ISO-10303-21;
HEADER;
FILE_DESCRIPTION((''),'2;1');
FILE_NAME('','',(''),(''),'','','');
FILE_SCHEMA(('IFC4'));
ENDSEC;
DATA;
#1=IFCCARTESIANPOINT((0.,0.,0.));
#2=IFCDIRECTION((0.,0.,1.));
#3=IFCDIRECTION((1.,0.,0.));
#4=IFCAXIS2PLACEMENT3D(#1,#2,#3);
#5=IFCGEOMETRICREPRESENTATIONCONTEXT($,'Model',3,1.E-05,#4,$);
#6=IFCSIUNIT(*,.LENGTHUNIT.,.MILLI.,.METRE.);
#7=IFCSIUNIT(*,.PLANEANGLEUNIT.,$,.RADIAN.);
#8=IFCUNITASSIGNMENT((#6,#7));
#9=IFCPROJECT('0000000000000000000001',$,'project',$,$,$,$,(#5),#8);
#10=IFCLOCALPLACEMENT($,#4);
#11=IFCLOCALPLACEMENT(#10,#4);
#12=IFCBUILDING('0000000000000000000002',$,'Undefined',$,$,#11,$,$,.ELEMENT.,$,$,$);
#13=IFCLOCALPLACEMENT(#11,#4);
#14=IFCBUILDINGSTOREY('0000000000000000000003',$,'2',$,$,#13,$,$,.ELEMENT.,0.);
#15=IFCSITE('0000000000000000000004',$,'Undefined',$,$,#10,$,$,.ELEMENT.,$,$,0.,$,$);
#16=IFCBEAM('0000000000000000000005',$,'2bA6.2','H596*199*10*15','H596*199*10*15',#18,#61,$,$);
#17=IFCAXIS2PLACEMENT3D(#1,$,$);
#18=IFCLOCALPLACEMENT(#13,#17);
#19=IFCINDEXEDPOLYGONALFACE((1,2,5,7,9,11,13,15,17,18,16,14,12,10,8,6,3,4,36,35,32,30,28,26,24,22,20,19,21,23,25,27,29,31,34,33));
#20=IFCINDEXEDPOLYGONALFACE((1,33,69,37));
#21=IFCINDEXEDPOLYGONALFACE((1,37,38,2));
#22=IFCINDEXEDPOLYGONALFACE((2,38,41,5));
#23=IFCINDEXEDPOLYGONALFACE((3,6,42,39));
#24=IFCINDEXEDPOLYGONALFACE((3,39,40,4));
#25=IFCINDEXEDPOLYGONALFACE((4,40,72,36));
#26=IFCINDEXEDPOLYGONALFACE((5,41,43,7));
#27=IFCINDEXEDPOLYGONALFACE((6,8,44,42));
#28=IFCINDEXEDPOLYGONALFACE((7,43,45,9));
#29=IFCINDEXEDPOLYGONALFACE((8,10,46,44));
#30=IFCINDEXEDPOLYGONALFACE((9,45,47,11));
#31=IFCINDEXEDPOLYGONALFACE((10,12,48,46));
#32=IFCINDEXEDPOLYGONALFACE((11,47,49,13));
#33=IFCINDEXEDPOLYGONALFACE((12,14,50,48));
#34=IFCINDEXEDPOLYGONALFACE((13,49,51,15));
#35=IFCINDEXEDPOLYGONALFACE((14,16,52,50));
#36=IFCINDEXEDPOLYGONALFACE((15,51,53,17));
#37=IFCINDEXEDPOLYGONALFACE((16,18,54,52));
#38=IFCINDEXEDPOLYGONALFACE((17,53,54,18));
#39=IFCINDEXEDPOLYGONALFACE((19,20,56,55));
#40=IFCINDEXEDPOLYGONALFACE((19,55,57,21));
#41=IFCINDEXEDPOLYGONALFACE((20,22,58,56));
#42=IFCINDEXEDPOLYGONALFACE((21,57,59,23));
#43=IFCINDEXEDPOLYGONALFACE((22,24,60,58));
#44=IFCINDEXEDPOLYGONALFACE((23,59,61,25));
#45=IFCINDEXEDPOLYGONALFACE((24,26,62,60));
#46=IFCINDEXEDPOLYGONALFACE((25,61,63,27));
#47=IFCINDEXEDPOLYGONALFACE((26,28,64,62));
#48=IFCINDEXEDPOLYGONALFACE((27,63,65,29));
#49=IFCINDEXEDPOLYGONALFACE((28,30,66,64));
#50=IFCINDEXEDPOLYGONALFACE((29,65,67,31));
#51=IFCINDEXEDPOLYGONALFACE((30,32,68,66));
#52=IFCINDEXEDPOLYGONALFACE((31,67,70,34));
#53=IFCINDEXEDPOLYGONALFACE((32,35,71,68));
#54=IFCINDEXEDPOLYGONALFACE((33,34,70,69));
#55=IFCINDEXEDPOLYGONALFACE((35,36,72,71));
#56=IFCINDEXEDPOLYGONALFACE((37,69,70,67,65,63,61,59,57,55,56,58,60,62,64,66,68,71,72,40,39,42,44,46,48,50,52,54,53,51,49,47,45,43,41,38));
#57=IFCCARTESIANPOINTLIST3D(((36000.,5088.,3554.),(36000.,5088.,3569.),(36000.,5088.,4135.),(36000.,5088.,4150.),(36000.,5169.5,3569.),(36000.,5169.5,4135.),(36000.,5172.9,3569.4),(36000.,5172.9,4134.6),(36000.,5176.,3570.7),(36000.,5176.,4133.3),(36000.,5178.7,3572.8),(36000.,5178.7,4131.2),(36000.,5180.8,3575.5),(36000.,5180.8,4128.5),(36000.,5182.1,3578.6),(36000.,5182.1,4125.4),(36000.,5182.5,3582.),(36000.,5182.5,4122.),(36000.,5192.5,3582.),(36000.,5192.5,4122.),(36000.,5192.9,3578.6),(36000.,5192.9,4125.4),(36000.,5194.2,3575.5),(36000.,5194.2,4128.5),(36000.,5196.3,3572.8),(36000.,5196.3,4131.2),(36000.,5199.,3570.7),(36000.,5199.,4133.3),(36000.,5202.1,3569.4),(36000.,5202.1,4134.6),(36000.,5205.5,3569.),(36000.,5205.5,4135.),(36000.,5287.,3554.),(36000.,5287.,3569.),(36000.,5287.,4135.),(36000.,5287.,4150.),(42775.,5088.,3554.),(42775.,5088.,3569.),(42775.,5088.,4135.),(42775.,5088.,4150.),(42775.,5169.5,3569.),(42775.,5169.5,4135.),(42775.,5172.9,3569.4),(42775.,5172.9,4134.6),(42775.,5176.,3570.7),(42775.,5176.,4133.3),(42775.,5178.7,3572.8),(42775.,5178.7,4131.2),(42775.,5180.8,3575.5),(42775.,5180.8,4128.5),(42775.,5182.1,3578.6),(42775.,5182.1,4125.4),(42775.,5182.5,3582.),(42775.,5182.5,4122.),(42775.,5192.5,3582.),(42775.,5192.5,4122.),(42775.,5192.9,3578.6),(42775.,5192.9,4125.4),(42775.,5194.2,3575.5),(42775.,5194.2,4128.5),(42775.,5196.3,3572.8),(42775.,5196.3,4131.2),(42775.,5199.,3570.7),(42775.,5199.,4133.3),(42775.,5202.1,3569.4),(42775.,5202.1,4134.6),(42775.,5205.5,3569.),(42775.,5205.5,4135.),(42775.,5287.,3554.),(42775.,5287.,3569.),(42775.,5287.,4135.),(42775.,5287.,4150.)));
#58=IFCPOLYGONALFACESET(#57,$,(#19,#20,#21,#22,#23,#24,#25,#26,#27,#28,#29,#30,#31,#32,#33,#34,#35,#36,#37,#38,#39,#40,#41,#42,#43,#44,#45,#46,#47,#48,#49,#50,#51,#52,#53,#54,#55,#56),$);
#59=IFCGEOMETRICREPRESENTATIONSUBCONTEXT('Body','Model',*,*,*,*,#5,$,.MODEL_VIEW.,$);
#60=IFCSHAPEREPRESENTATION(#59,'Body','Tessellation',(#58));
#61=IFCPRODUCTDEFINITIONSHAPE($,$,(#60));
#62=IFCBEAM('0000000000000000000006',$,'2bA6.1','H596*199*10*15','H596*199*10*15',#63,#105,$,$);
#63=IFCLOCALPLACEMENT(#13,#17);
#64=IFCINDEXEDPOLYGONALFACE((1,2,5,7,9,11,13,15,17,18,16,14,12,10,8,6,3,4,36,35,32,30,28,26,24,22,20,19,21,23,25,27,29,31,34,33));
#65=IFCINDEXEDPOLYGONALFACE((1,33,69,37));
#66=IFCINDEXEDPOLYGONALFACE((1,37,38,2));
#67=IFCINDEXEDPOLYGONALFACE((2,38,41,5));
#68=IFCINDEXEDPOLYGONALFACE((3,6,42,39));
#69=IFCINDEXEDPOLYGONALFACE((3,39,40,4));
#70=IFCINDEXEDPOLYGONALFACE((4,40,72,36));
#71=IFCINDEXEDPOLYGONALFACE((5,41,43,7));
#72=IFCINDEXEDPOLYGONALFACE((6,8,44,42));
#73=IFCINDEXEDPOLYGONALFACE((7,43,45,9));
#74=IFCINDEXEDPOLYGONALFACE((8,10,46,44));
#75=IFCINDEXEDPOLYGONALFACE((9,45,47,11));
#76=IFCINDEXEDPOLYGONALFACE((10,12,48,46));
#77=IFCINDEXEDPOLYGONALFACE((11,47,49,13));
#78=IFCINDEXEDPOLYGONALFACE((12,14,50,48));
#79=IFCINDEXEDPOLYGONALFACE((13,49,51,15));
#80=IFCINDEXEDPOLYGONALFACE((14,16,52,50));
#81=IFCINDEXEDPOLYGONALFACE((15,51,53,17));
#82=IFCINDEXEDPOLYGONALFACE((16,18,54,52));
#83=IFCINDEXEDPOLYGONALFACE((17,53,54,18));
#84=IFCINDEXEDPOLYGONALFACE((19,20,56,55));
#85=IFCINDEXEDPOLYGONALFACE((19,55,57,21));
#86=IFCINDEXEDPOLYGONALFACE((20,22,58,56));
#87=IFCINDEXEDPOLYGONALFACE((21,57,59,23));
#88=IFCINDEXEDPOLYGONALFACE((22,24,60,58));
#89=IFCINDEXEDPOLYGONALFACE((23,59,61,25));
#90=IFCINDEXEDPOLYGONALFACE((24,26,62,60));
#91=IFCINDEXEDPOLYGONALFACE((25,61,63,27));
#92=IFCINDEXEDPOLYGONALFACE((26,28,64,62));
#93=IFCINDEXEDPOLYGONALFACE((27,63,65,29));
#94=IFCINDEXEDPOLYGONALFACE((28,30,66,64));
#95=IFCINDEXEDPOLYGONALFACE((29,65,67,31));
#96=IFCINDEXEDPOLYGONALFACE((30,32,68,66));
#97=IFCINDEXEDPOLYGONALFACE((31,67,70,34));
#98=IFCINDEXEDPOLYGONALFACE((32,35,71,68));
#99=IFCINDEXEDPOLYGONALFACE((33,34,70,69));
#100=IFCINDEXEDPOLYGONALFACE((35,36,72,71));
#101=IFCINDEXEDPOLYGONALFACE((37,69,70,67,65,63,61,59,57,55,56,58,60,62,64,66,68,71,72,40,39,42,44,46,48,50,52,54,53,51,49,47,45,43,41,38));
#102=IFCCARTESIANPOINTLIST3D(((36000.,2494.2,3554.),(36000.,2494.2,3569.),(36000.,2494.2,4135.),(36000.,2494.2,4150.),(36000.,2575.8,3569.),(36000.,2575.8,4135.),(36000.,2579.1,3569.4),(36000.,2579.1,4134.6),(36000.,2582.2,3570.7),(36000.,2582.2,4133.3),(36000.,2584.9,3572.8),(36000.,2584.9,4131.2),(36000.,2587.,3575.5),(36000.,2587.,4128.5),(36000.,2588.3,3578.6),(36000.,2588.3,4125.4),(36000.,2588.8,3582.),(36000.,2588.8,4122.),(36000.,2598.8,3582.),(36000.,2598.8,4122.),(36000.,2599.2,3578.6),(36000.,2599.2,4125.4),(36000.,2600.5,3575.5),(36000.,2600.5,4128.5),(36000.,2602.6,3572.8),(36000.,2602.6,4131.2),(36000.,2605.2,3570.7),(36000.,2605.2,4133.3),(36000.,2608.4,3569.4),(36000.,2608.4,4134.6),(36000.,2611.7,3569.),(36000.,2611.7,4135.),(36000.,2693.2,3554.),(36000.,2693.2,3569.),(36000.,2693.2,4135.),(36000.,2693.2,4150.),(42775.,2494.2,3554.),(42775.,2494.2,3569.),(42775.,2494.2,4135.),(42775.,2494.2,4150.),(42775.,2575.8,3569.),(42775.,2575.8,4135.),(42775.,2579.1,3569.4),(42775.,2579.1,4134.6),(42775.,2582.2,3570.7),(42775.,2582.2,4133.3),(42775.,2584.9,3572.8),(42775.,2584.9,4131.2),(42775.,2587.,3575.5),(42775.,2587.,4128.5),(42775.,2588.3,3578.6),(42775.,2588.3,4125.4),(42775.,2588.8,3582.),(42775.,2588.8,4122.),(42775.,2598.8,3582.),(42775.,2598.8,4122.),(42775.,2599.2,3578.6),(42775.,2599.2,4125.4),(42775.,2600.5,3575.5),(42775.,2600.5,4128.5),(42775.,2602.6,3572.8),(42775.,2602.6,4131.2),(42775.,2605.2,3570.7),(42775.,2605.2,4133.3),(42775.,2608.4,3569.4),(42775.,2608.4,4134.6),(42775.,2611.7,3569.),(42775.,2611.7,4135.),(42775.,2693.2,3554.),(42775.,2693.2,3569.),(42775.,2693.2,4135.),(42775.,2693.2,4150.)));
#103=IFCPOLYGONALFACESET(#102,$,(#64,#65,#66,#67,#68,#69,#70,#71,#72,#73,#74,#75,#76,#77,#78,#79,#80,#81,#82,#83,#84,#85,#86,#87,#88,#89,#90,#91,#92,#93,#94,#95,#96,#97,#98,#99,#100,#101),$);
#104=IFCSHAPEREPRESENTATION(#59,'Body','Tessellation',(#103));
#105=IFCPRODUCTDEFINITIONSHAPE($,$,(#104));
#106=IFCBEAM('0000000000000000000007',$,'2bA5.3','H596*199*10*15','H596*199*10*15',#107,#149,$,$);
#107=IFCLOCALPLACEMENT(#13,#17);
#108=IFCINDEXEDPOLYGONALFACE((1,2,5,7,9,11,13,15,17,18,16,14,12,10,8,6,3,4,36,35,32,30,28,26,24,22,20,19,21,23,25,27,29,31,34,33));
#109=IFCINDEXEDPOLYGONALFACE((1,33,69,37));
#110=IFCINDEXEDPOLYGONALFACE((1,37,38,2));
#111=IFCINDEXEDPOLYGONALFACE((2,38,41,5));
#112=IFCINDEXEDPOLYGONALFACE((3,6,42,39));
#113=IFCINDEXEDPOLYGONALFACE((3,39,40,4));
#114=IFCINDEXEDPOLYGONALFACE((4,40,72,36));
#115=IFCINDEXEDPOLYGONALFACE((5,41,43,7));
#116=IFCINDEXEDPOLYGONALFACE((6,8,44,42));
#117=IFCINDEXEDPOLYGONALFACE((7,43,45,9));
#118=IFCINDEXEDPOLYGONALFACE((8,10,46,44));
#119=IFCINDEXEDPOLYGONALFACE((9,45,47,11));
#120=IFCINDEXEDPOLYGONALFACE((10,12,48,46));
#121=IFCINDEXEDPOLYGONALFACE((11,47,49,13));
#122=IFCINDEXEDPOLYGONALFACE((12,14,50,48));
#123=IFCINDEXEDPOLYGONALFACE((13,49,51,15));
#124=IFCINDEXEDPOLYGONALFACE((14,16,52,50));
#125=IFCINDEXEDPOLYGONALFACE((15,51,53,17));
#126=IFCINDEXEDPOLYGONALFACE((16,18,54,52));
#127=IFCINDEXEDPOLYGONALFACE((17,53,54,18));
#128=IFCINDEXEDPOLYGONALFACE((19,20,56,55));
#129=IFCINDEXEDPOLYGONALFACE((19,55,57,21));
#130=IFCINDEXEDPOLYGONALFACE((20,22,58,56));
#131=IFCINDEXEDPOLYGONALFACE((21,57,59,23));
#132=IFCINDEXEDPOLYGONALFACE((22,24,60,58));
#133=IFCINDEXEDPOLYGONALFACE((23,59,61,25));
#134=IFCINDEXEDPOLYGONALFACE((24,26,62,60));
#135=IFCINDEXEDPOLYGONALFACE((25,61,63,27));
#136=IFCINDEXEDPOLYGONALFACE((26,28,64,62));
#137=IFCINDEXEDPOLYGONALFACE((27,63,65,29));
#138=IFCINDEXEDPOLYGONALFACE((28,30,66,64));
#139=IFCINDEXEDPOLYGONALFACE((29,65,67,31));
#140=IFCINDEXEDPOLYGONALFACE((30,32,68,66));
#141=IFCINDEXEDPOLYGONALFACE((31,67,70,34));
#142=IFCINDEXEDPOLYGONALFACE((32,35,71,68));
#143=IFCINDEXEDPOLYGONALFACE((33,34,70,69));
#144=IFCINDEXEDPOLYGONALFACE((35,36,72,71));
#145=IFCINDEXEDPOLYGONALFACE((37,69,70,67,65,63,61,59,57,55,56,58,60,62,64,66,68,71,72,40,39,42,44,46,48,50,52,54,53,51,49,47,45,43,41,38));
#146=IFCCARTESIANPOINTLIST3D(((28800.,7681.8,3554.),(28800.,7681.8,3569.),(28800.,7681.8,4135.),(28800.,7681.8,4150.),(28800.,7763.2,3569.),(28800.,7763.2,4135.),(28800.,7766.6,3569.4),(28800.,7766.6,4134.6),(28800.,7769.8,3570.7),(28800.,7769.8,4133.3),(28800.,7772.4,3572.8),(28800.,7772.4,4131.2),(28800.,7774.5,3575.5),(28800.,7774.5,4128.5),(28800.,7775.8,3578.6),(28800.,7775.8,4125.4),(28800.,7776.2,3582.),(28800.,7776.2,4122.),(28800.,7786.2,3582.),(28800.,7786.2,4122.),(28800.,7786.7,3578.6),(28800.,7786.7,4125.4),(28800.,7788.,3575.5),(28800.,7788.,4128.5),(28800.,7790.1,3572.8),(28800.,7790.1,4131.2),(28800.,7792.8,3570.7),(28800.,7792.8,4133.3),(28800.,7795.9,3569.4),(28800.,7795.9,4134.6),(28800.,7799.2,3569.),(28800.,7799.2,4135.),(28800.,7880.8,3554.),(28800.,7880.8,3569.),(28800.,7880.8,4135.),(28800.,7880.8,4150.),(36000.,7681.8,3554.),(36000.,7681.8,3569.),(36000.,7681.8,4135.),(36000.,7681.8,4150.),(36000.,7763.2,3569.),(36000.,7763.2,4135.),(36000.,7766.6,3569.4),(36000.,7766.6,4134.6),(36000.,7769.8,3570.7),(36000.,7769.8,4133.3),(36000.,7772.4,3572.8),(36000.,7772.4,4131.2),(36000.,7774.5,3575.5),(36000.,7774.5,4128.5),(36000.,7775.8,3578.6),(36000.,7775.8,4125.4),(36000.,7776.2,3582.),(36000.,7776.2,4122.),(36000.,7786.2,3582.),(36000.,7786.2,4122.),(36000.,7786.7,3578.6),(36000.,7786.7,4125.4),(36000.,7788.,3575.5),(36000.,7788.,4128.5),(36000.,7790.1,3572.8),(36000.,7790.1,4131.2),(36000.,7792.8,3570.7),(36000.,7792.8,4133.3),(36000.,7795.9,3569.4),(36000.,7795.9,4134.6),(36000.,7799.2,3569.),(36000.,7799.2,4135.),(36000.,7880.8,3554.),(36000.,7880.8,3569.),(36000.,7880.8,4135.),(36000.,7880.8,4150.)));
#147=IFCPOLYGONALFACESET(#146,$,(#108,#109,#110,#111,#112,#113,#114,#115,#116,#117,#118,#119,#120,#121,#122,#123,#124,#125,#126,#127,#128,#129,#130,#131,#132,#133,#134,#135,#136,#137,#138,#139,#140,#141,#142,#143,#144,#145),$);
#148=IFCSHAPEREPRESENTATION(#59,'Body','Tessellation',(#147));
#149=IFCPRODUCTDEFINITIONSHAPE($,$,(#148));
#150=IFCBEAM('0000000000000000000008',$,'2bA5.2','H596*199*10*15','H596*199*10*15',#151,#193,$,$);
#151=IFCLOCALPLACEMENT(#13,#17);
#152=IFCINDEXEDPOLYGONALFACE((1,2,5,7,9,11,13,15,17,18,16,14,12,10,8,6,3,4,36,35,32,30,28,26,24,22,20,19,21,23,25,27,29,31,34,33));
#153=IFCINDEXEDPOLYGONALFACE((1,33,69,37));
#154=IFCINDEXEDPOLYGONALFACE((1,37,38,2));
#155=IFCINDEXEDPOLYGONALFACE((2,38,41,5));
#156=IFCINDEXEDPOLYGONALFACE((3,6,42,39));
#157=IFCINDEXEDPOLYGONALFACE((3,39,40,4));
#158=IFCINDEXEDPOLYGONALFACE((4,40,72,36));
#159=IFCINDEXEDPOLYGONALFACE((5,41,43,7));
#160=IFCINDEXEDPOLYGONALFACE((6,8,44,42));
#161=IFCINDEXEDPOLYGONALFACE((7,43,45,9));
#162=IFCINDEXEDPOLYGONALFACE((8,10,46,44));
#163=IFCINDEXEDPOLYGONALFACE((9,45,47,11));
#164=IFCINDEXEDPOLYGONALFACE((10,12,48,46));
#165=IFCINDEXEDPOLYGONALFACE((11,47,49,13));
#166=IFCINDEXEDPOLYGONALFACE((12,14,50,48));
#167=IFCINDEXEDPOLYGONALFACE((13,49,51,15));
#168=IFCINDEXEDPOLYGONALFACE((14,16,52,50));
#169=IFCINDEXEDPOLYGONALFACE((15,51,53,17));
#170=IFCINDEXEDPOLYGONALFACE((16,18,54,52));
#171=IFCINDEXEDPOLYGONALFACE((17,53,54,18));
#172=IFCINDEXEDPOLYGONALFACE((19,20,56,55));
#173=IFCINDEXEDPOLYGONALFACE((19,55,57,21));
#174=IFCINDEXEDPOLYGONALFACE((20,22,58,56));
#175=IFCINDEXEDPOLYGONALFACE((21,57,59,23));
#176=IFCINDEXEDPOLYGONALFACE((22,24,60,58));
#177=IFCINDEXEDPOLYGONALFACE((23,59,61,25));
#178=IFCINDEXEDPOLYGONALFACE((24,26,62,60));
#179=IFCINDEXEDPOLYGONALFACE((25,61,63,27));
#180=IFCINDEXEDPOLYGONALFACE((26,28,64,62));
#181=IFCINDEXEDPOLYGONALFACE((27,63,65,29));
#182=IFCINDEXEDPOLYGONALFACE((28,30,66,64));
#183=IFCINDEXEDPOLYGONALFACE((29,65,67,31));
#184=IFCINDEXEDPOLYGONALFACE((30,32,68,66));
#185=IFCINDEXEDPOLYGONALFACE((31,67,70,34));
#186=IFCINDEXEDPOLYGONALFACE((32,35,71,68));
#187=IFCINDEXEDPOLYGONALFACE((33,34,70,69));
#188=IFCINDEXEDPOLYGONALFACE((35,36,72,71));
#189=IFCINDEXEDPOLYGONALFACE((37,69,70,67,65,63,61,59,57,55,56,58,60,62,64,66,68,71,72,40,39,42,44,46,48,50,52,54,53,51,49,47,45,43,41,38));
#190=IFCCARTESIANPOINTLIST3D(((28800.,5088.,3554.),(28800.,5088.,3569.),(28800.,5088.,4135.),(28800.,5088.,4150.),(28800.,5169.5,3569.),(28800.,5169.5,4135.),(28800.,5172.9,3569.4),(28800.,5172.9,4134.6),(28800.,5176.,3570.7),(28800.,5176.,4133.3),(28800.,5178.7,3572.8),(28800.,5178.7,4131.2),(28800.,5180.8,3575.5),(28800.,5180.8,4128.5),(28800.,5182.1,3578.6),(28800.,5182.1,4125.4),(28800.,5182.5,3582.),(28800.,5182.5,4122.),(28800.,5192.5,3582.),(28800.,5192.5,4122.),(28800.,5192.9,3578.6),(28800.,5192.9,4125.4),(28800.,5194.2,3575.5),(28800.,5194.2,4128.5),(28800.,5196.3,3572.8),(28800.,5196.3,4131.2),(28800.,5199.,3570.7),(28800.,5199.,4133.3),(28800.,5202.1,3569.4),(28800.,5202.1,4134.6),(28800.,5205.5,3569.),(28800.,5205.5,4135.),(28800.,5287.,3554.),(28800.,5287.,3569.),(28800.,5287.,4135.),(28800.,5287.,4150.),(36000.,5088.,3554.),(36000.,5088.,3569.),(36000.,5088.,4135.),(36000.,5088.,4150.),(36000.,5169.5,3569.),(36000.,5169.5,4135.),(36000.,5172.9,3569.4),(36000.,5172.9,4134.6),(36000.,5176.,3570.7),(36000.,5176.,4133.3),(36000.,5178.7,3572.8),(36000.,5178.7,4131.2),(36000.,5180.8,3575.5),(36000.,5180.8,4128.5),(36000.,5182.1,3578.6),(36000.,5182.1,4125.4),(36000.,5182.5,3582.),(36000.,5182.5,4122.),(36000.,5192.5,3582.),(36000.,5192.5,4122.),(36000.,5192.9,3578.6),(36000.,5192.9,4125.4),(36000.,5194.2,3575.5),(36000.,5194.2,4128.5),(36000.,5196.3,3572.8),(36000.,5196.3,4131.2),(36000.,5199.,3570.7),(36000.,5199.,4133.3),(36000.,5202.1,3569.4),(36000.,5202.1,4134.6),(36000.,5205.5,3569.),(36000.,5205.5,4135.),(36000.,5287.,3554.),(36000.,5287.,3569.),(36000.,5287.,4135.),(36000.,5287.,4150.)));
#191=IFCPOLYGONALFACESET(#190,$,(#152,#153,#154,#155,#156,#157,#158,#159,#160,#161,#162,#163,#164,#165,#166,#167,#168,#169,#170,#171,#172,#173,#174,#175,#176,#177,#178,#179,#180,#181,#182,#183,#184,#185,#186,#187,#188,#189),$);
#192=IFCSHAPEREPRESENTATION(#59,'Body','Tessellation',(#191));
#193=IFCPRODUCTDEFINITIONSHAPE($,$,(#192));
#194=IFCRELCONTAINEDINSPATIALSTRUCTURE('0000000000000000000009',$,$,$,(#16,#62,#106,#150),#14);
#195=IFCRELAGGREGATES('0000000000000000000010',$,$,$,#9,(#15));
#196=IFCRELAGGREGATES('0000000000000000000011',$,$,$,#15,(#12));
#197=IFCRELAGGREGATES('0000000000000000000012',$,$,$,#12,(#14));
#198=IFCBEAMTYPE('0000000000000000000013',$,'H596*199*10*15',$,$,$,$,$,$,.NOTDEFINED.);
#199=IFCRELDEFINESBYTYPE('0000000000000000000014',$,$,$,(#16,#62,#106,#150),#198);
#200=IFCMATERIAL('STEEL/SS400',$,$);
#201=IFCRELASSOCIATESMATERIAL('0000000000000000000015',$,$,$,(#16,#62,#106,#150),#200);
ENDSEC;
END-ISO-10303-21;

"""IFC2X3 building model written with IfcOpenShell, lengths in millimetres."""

from ifc_helpers import new_model, si_unit, frame, origin_with_axes, origin_2d_with_axis, place, context, subcontext, project, spatial, i_section, extrude, material, type_object, element, save


model = new_model("IFC2X3")

# Units and contexts
model_context = context("Model", 3, precision=1e-05, world=origin_with_axes())
body_context = subcontext(model_context, "Body", "Model", "MODEL_VIEW")
ifc_project = project(units=[si_unit("LENGTHUNIT", "METRE", prefix="MILLI"), si_unit("PLANEANGLEUNIT", "RADIAN")], contexts=[model_context])

# Site, building, storey
site_placement = place(None, origin_with_axes())
site = spatial("IfcSite", under=ifc_project, at=site_placement, Name="Undefined", CompositionType="ELEMENT", RefElevation=0.0)
building_placement = place(site_placement, origin_with_axes())
building = spatial("IfcBuilding", under=site, at=building_placement, Name="Undefined", CompositionType="ELEMENT")
storey_placement = place(building_placement, origin_with_axes())
storey = spatial("IfcBuildingStorey", under=building, at=storey_placement, Name="2", CompositionType="ELEMENT", Elevation=0.0)

# Beams
ifc_material_1 = material(Name="STEEL/SS400")
beam_type_1 = type_object("IfcBeamType", Name="H596*199*10*15", PredefinedType="NOTDEFINED")
for number, where, z_axis, x_axis, name in (
    (1, (36000.0, 5187.5, 3852.0), (0.0, 0.0, 1.0), (1.0, 0.0, 0.0), "2bA6.2"),
    (2, (36000.0, 2593.8, 3852.0), (0.0, 0.0, 1.0), (1.0, 0.0, 0.0), "2bA6.1"),
):
    element("IfcBeam", number, at=place(storey_placement, frame(where, z_axis=z_axis, x_axis=x_axis)), inside=storey, type_object=beam_type_1, material=ifc_material_1, Name=name, Description="H596*199*10*15", ObjectType="H596*199*10*15", context=body_context, shape_type="SweptSolid", body=[
        extrude(i_section(OverallWidth=199.0, OverallDepth=596.0, WebThickness=10.0, FlangeThickness=15.0, FilletRadius=13.0, at=origin_2d_with_axis()), frame((6775.0, 0.0, 0.0), z_axis=(-1.0, 0.0, 0.0), x_axis=(0.0, -1.0, 0.0)), (0.0, 0.0, 1.0), 6775.0),
    ])
for number, where, z_axis, x_axis, name in (
    (3, (28800.0, 7781.2, 3852.0), (0.0, 0.0, 1.0), (1.0, 0.0, 0.0), "2bA5.3"),
    (4, (28800.0, 5187.5, 3852.0), (0.0, 0.0, 1.0), (1.0, 0.0, 0.0), "2bA5.2"),
):
    element("IfcBeam", number, at=place(storey_placement, frame(where, z_axis=z_axis, x_axis=x_axis)), inside=storey, type_object=beam_type_1, material=ifc_material_1, Name=name, Description="H596*199*10*15", ObjectType="H596*199*10*15", context=body_context, shape_type="SweptSolid", body=[
        extrude(i_section(OverallWidth=199.0, OverallDepth=596.0, WebThickness=10.0, FlangeThickness=15.0, FilletRadius=13.0, at=origin_2d_with_axis()), frame((7200.0, 0.0, 0.0), z_axis=(-1.0, 0.0, 0.0), x_axis=(0.0, -1.0, 0.0)), (0.0, 0.0, 1.0), 7200.0),
    ])

save(model, "model.ifc")
